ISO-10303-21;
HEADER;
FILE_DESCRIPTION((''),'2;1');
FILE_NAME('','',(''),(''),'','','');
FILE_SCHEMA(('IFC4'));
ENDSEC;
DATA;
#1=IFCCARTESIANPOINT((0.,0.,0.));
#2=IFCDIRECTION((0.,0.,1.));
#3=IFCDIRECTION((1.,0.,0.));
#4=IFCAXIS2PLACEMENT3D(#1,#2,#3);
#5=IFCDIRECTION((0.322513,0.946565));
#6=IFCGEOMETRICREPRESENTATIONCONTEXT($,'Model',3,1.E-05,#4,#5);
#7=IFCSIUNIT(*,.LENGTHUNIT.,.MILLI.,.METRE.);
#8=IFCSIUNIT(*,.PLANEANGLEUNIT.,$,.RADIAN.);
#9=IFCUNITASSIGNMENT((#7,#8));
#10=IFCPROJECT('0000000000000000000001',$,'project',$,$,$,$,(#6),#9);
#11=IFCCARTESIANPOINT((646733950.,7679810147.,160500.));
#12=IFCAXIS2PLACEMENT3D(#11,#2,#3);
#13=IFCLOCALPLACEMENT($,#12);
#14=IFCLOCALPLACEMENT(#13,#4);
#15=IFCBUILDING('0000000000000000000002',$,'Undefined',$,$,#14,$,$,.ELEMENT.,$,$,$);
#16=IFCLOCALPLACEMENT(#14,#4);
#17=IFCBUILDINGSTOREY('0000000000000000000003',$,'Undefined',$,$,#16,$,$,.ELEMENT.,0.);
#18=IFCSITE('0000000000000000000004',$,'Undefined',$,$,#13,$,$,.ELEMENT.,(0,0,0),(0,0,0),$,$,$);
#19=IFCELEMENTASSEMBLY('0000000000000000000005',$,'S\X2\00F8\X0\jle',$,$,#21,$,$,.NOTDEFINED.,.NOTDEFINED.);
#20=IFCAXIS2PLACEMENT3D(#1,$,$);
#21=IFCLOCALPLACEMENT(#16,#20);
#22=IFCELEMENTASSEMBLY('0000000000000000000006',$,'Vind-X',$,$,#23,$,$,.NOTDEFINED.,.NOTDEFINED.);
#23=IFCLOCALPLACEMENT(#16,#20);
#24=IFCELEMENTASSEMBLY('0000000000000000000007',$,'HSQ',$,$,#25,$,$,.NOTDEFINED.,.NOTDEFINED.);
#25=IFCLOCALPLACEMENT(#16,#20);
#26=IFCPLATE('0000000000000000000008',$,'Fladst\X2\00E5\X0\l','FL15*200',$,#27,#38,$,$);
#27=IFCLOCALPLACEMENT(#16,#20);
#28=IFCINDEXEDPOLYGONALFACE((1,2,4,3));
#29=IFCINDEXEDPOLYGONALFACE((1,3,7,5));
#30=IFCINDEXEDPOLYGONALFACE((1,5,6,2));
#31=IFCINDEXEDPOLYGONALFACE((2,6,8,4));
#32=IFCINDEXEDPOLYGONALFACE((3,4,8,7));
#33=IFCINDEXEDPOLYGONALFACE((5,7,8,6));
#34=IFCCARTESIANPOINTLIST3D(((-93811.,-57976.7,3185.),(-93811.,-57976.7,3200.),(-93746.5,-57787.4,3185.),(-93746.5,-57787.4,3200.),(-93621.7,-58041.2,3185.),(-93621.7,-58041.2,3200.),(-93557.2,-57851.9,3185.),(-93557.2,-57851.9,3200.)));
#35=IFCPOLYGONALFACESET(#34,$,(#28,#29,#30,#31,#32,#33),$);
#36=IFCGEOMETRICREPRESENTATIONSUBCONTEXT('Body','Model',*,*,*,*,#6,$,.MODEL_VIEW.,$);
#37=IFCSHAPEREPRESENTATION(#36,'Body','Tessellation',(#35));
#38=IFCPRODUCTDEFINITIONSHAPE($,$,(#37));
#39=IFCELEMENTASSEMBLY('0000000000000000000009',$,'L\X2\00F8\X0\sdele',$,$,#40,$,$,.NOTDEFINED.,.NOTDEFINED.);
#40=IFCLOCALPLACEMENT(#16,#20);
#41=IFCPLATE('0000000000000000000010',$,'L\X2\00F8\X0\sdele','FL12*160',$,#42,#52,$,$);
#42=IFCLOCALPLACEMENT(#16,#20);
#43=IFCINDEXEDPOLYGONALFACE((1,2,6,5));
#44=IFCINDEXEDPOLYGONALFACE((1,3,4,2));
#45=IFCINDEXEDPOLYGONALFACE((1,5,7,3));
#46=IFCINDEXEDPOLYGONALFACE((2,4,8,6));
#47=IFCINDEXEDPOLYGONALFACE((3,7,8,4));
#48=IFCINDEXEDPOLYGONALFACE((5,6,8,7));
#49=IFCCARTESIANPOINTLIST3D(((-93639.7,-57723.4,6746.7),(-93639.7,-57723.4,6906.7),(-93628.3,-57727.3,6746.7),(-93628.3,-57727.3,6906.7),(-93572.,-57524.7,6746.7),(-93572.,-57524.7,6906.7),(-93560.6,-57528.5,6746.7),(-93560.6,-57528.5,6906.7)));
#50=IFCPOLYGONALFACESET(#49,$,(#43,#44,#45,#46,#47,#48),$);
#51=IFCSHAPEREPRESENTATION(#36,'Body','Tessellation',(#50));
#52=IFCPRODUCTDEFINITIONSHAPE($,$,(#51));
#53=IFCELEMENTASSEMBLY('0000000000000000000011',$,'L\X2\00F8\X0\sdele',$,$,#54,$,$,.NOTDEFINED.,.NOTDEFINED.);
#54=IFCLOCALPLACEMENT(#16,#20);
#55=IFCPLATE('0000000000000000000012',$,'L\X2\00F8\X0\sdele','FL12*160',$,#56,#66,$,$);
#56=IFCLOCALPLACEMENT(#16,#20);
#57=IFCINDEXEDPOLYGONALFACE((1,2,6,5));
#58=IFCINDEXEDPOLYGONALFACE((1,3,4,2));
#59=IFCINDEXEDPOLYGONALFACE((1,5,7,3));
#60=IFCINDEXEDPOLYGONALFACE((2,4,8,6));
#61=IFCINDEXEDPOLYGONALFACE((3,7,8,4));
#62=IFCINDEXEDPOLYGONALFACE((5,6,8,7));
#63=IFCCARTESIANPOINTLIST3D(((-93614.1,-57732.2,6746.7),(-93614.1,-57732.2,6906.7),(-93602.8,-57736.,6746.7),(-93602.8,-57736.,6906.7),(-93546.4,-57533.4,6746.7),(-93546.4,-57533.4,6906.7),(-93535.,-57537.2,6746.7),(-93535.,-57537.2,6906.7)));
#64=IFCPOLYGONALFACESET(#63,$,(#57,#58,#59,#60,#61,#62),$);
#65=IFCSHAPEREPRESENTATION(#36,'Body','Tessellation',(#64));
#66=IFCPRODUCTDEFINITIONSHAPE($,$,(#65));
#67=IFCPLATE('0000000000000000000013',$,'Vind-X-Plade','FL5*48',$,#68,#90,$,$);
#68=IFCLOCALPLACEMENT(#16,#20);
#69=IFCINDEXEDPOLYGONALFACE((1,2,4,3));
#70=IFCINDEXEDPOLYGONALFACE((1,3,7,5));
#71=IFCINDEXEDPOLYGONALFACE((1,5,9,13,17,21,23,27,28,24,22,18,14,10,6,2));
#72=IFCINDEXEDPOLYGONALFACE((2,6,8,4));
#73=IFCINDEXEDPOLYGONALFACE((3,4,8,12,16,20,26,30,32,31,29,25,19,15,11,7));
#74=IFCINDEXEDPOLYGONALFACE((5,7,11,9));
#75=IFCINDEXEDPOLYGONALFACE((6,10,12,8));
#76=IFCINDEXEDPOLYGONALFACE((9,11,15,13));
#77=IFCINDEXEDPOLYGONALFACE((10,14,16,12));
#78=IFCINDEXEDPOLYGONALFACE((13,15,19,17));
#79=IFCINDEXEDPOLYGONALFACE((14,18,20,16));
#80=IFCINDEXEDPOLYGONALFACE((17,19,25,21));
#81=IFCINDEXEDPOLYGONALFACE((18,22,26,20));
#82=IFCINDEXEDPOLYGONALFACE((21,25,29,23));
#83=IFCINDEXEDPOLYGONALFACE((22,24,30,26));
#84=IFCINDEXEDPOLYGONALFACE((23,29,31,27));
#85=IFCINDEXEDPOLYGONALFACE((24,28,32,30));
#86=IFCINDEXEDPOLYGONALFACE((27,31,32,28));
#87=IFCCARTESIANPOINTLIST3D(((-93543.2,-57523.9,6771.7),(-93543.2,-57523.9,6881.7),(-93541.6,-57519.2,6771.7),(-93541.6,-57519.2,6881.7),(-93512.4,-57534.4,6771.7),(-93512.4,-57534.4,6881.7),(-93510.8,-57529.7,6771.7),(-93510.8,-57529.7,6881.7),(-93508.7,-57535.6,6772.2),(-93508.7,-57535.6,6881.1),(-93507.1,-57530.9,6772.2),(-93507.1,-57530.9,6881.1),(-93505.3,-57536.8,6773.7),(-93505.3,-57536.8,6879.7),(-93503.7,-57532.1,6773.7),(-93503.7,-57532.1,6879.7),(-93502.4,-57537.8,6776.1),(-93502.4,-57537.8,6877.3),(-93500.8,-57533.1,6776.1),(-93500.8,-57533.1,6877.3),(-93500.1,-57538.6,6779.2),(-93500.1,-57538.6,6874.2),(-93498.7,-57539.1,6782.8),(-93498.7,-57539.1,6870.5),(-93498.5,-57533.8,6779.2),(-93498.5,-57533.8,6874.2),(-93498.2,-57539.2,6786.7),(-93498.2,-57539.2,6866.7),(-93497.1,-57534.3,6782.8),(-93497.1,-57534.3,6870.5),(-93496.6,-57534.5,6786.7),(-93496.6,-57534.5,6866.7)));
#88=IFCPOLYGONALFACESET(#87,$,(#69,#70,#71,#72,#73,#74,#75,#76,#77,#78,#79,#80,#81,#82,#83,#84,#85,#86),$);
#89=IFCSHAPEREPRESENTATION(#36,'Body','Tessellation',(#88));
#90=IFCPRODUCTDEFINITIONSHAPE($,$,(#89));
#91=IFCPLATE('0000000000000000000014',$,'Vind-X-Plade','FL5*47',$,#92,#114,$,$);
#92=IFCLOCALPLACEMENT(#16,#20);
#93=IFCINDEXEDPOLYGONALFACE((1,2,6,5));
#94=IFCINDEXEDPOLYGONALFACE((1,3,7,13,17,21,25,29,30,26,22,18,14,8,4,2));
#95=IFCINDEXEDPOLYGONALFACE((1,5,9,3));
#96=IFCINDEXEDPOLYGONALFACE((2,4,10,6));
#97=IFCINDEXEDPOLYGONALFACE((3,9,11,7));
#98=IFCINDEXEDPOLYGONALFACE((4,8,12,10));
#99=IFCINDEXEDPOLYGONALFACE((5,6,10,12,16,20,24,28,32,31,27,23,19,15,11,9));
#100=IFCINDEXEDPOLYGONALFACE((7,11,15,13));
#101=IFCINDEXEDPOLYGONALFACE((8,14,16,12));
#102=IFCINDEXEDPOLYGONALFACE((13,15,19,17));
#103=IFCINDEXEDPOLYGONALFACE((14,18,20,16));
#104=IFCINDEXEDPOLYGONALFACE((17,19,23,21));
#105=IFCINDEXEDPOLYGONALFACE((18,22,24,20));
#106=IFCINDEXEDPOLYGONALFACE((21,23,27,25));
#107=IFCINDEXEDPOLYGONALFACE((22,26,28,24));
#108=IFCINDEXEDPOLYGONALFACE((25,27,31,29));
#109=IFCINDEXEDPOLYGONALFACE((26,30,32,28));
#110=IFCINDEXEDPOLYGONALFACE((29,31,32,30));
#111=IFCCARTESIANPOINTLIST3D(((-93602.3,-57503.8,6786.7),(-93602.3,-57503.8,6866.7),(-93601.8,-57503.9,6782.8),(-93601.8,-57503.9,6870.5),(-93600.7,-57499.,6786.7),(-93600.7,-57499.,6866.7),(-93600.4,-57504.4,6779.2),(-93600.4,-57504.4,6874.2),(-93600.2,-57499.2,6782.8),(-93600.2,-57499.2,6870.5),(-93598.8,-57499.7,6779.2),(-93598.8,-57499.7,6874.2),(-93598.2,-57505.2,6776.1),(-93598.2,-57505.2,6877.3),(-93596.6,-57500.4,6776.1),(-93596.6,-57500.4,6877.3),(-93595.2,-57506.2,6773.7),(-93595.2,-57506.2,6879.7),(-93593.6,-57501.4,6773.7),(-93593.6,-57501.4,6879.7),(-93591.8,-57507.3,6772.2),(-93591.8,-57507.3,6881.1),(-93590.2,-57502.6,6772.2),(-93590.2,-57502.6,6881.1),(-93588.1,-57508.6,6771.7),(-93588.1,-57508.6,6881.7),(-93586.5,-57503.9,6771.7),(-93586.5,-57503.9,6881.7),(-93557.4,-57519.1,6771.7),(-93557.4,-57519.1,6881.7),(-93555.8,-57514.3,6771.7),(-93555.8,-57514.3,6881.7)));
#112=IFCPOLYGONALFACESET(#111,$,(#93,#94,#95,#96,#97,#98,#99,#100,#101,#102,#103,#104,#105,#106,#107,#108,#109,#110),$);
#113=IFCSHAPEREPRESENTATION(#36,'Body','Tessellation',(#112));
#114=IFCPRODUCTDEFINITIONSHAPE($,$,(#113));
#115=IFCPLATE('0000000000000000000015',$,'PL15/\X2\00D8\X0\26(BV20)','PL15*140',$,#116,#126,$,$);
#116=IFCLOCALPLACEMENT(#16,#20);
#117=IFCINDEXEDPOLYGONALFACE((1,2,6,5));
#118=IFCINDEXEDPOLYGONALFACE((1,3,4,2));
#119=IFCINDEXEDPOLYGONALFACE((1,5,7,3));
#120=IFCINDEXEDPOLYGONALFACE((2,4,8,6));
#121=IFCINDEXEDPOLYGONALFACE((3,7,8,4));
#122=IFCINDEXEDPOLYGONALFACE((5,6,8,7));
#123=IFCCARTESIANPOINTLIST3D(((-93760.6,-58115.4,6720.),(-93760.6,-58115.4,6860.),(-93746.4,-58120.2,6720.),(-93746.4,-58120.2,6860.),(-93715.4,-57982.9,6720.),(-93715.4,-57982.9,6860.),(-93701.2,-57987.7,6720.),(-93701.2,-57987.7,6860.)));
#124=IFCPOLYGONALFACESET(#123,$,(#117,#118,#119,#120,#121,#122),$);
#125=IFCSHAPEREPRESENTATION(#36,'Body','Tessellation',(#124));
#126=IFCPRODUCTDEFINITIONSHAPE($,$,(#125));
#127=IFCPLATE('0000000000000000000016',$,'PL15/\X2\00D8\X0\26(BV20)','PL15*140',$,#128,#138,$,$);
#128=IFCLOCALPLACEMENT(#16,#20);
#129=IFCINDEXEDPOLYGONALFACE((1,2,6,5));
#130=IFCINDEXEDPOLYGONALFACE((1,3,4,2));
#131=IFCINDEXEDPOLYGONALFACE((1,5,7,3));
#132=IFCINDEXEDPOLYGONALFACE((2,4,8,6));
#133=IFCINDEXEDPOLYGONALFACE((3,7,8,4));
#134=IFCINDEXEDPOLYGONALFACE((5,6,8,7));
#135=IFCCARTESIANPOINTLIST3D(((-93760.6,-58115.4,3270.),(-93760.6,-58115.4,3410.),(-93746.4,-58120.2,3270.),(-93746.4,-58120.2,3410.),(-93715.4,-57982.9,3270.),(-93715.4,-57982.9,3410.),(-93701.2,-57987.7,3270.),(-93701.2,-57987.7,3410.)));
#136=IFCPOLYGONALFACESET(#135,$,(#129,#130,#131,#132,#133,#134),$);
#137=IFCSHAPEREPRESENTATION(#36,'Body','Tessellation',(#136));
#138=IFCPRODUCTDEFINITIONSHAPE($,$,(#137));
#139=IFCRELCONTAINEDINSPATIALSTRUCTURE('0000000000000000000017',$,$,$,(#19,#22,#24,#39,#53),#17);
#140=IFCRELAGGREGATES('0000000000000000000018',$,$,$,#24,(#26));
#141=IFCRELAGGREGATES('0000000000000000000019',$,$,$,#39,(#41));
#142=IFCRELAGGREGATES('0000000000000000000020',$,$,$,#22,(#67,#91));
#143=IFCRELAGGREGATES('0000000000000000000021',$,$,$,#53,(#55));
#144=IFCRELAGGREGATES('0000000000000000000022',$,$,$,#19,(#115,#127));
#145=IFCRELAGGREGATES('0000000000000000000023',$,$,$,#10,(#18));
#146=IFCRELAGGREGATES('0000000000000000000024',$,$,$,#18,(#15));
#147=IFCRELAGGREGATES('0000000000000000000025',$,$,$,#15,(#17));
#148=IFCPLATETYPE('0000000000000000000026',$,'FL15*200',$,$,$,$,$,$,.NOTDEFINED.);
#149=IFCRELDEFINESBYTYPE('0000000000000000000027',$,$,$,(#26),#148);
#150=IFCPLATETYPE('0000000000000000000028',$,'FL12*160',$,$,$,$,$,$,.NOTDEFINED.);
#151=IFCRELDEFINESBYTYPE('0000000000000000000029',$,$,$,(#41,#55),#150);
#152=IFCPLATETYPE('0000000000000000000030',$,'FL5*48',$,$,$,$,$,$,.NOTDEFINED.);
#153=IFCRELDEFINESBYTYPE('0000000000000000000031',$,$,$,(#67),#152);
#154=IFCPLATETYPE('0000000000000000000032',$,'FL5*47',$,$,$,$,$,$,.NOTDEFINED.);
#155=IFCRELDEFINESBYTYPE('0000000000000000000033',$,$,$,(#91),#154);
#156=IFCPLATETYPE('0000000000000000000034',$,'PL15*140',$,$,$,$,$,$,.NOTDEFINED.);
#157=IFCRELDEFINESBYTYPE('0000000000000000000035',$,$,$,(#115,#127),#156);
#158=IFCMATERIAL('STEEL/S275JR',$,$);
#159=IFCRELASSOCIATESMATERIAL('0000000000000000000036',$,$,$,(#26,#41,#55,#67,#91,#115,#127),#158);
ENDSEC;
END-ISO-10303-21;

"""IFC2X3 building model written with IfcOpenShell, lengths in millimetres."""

from ifc_helpers import new_model, si_unit, direction, frame, frame_2d, origin_with_axes, place, context, subcontext, project, spatial, polyline, circle_curve, parameter, trimmed, segment, composite_curve, outline, extrude, material, type_object, element, aggregate, save


model = new_model("IFC2X3")

# Units and contexts
model_context = context("Model", 3, precision=1e-05, world=origin_with_axes(), true_north=direction((0.322513, 0.946565)))
body_context = subcontext(model_context, "Body", "Model", "MODEL_VIEW")
ifc_project = project(units=[si_unit("LENGTHUNIT", "METRE", prefix="MILLI"), si_unit("PLANEANGLEUNIT", "RADIAN")], contexts=[model_context])

# Site, building, storey
site_placement = place(None, frame((646733950.0, 7679810147.0, 160500.0), z_axis=(0.0, 0.0, 1.0), x_axis=(1.0, 0.0, 0.0)))
site = spatial("IfcSite", under=ifc_project, at=site_placement, Name="Undefined", CompositionType="ELEMENT", RefLatitude=(0, 0, 0), RefLongitude=(0, 0, 0))
building_placement = place(site_placement, origin_with_axes())
building = spatial("IfcBuilding", under=site, at=building_placement, Name="Undefined", CompositionType="ELEMENT")
storey_placement = place(building_placement, origin_with_axes())
storey = spatial("IfcBuildingStorey", under=building, at=storey_placement, Name="Undefined", CompositionType="ELEMENT", Elevation=0.0)

# Element assembly
assembly_1_placement = place(storey_placement, origin_with_axes())
assembly_1 = element("IfcElementAssembly", 1, at=assembly_1_placement, inside=storey, Name="Søjle", AssemblyPlace="NOTDEFINED", PredefinedType="NOTDEFINED")

# Shared definitions
ifc_material_1 = material(Name="STEEL/S275JR")

# Element assembly
assembly_2_placement = place(storey_placement, origin_with_axes())
assembly_2 = element("IfcElementAssembly", 2, at=assembly_2_placement, inside=storey, Name="Vind-X", AssemblyPlace="NOTDEFINED", PredefinedType="NOTDEFINED")

# Shared definitions
plate_type_1 = type_object("IfcPlateType", Name="FL15*200", PredefinedType="NOTDEFINED")

# Element assemblies, plates
assembly_3_placement = place(storey_placement, origin_with_axes())
assembly_3 = element("IfcElementAssembly", 3, at=assembly_3_placement, inside=storey, Name="HSQ", AssemblyPlace="NOTDEFINED", PredefinedType="NOTDEFINED")
plate_1_placement = place(assembly_3_placement, frame((-93621.7, -58041.2, 3192.5), z_axis=(0.0, 0.0, 1.0), x_axis=(0.322513, 0.946565, 0.0)))
plate_1 = element("IfcPlate", 4, at=plate_1_placement, type_object=plate_type_1, material=ifc_material_1, Name="Fladstål", Description="FL15*200", context=body_context, shape_type="SweptSolid", body=[
    extrude(outline(polyline([(0.0, 0.0), (200.0, 0.0), (200.0, 200.0), (0.0, 200.0), (0.0, 0.0)])), frame((0.0, 0.0, -7.5), z_axis=(0.0, 0.0, 1.0), x_axis=(1.0, 0.0, 0.0)), (0.0, 0.0, 1.0), 15.0),
])
aggregate(assembly_3, [plate_1])
assembly_4_placement = place(storey_placement, origin_with_axes())
assembly_4 = element("IfcElementAssembly", 5, at=assembly_4_placement, inside=storey, Name="Løsdele", AssemblyPlace="NOTDEFINED", PredefinedType="NOTDEFINED")
plate_type_2 = type_object("IfcPlateType", Name="FL12*160", PredefinedType="NOTDEFINED")
plate_2_placement = place(assembly_4_placement, frame((-93634.0, -57725.4, 6826.7), z_axis=(-0.946565, 0.322513, 0.0), x_axis=(0.322513, 0.946565, 0.0)))
plate_2 = element("IfcPlate", 6, at=plate_2_placement, type_object=plate_type_2, material=ifc_material_1, Name="Løsdele", Description="FL12*160", context=body_context, shape_type="SweptSolid", body=[
    extrude(outline(polyline([(0.0, -80.0), (0.0, 80.0), (210.0, 80.0), (210.0, -80.0), (0.0, -80.0)])), frame((0.0, 0.0, -6.0), z_axis=(0.0, 0.0, 1.0), x_axis=(1.0, 0.0, 0.0)), (0.0, 0.0, 1.0), 12.0),
])
aggregate(assembly_4, [plate_2])
assembly_5_placement = place(storey_placement, origin_with_axes())
assembly_5 = element("IfcElementAssembly", 7, at=assembly_5_placement, inside=storey, Name="Løsdele", AssemblyPlace="NOTDEFINED", PredefinedType="NOTDEFINED")
plate_3_placement = place(assembly_5_placement, frame((-93608.4, -57734.1, 6826.7), z_axis=(-0.946565, 0.322513, 0.0), x_axis=(0.322513, 0.946565, 0.0)))
plate_3 = element("IfcPlate", 8, at=plate_3_placement, type_object=plate_type_2, material=ifc_material_1, Name="Løsdele", Description="FL12*160", context=body_context, shape_type="SweptSolid", body=[
    extrude(outline(polyline([(0.0, -80.0), (0.0, 80.0), (210.0, 80.0), (210.0, -80.0), (0.0, -80.0)])), frame((0.0, 0.0, -6.0), z_axis=(0.0, 0.0, 1.0), x_axis=(1.0, 0.0, 0.0)), (0.0, 0.0, 1.0), 12.0),
])

# Plates
plate_type_3 = type_object("IfcPlateType", Name="FL5*48", PredefinedType="NOTDEFINED")
plate_4_placement = place(assembly_2_placement, frame((-93497.4, -57536.9, 6771.7), z_axis=(0.322513, 0.946565, 0.0), x_axis=(-0.946565, 0.322513, 0.0)))
plate_4 = element("IfcPlate", 9, at=plate_4_placement, type_object=plate_type_3, material=ifc_material_1, Name="Vind-X-Plade", Description="FL5*48", context=body_context, shape_type="SweptSolid", body=[
    extrude(outline(composite_curve([segment(trimmed(circle_curve(frame_2d((15.0, 15.0), x_axis=(-1.0, 0.0)), 15.0), [parameter(0.0)], [parameter(1.570796)], True, "PARAMETER"), True, "CONTINUOUS"), segment(polyline([(15.0, 0.0), (47.5, 0.0), (47.5, 110.0), (15.0, 110.0)]), True, "CONTINUOUS"), segment(trimmed(circle_curve(frame_2d((15.0, 95.0), x_axis=(0.0, 1.0)), 15.0), [parameter(0.0)], [parameter(1.570796)], True, "PARAMETER"), True, "CONTINUOUS"), segment(polyline([(0.0, 95.0), (0.0, 15.0)]), True, "CONTINUOUS")], self_intersect=True)), frame((0.0, 0.0, -2.5), z_axis=(0.0, 0.0, 1.0), x_axis=(1.0, 0.0, 0.0)), (0.0, 0.0, 1.0), 5.0),
])
plate_type_4 = type_object("IfcPlateType", Name="FL5*47", PredefinedType="NOTDEFINED")
plate_5_placement = place(assembly_2_placement, frame((-93556.6, -57516.7, 6771.7), z_axis=(0.322513, 0.946565, 0.0), x_axis=(-0.946565, 0.322513, 0.0)))
plate_5 = element("IfcPlate", 10, at=plate_5_placement, type_object=plate_type_4, material=ifc_material_1, Name="Vind-X-Plade", Description="FL5*47", context=body_context, shape_type="SweptSolid", body=[
    extrude(outline(composite_curve([segment(polyline([(0.0, 0.0), (32.5, 0.0)]), True, "CONTINUOUS"), segment(trimmed(circle_curve(frame_2d((32.5, 15.0), x_axis=(0.0, -1.0)), 15.0), [parameter(0.0)], [parameter(1.570796)], True, "PARAMETER"), True, "CONTINUOUS"), segment(polyline([(47.5, 15.0), (47.5, 95.0)]), True, "CONTINUOUS"), segment(trimmed(circle_curve(frame_2d((32.5, 95.0), x_axis=(1.0, 0.0)), 15.0), [parameter(0.0)], [parameter(1.570796)], True, "PARAMETER"), True, "CONTINUOUS"), segment(polyline([(32.5, 110.0), (0.0, 110.0), (0.0, 0.0)]), True, "CONTINUOUS")], self_intersect=True)), frame((0.0, 0.0, -2.5), z_axis=(0.0, 0.0, 1.0), x_axis=(1.0, 0.0, 0.0)), (0.0, 0.0, 1.0), 5.0),
])
aggregate(assembly_2, [plate_4, plate_5])
plate_type_5 = type_object("IfcPlateType", Name="PL15*140", PredefinedType="NOTDEFINED")
plate_6_placement = place(assembly_1_placement, frame((-93708.3, -57985.3, 6720.0), z_axis=(-0.946565, 0.322513, 0.0), x_axis=(-0.322513, -0.946565, 0.0)))
plate_6 = element("IfcPlate", 11, at=plate_6_placement, type_object=plate_type_5, material=ifc_material_1, Name="PL15/Ø26(BV20)", Description="PL15*140", context=body_context, shape_type="SweptSolid", body=[
    extrude(outline(polyline([(0.0, 0.0), (140.0, 0.0), (140.0, 140.0), (0.0, 140.0), (0.0, 0.0)])), frame((0.0, 0.0, -7.5), z_axis=(0.0, 0.0, 1.0), x_axis=(1.0, 0.0, 0.0)), (0.0, 0.0, 1.0), 15.0),
])
plate_7_placement = place(assembly_1_placement, frame((-93708.3, -57985.3, 3270.0), z_axis=(-0.946565, 0.322513, 0.0), x_axis=(-0.322513, -0.946565, 0.0)))
plate_7 = element("IfcPlate", 12, at=plate_7_placement, type_object=plate_type_5, material=ifc_material_1, Name="PL15/Ø26(BV20)", Description="PL15*140", context=body_context, shape_type="SweptSolid", body=[
    extrude(outline(polyline([(0.0, 0.0), (140.0, 0.0), (140.0, 140.0), (0.0, 140.0), (0.0, 0.0)])), frame((0.0, 0.0, -7.5), z_axis=(0.0, 0.0, 1.0), x_axis=(1.0, 0.0, 0.0)), (0.0, 0.0, 1.0), 15.0),
])

aggregate(assembly_5, [plate_3])
aggregate(assembly_1, [plate_6, plate_7])

save(model, "model.ifc")
